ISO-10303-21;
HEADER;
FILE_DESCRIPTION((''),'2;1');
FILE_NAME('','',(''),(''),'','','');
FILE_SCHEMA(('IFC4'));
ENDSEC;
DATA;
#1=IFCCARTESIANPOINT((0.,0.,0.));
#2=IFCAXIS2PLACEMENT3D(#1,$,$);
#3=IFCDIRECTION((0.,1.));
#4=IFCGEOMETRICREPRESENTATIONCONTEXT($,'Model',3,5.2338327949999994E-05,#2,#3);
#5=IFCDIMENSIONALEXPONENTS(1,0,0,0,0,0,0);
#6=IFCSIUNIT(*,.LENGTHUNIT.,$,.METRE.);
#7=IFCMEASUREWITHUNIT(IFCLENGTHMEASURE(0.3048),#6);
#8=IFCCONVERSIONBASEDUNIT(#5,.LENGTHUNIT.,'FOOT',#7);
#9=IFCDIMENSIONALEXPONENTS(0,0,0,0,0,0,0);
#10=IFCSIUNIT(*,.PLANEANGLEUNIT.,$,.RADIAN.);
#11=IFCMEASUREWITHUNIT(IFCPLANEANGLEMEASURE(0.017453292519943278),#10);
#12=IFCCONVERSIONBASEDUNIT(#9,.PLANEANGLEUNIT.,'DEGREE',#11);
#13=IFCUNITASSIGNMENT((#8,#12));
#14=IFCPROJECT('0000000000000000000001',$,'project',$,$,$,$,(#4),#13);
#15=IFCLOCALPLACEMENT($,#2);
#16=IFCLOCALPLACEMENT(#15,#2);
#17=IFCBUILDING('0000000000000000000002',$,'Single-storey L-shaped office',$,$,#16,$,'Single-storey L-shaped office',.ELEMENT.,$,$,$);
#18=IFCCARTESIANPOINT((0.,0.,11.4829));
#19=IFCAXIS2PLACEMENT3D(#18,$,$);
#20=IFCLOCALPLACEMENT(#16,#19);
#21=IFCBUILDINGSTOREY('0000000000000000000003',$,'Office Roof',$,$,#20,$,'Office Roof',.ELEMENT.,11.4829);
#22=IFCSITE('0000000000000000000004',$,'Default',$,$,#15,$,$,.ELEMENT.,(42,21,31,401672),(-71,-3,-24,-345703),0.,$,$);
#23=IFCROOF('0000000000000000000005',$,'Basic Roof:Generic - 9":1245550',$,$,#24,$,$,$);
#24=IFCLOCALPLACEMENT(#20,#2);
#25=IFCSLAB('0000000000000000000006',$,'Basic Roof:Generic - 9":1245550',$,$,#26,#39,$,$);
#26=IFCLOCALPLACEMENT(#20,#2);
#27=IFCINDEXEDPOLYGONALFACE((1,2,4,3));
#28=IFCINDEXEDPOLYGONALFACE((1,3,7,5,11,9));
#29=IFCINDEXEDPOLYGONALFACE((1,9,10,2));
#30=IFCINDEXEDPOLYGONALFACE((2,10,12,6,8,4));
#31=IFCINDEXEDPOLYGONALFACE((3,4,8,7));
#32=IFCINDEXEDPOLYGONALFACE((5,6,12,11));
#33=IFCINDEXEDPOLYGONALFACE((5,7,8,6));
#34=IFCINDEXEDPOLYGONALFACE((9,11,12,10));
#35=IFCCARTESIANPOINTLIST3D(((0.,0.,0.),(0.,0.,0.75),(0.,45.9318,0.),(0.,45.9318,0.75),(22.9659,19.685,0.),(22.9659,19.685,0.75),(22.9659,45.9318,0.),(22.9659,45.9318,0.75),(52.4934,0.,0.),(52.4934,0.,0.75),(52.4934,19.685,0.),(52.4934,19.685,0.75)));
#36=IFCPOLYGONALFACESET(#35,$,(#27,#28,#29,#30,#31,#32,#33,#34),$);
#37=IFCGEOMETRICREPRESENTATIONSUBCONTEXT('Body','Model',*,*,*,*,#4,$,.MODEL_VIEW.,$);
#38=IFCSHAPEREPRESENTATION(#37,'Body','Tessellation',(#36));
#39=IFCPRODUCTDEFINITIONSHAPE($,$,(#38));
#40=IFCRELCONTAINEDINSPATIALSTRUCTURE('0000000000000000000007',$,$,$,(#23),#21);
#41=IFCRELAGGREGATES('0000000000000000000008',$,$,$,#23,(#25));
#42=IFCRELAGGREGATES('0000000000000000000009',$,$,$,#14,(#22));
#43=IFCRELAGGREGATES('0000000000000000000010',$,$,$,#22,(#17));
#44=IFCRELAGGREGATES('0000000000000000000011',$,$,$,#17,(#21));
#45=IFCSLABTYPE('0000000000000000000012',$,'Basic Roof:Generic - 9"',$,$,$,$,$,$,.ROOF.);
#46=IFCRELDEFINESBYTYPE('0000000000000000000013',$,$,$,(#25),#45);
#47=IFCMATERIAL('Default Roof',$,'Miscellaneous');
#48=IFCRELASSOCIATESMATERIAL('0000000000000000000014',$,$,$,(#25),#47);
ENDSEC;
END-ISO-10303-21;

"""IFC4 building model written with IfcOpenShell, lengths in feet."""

from ifc_helpers import new_model, entity, si_unit, converted_unit, direction, frame, origin, place, context, subcontext, project, spatial, indexed_curve, outline, extrude, material, type_object, element, aggregate, save


model = new_model("IFC4")

# Units and contexts
model_context = context("Model", 3, precision=5.2338327949999994e-05, world=origin(), true_north=direction((0.0, 1.0)))
body_context = subcontext(model_context, "Body", "Model", "MODEL_VIEW")
ifc_project = project(units=[converted_unit("LENGTHUNIT", "FOOT", entity("IfcLengthMeasure", 0.3048), si_unit("LENGTHUNIT", "METRE"), dimensions=[1, 0, 0, 0, 0, 0, 0]), converted_unit("PLANEANGLEUNIT", "DEGREE", entity("IfcPlaneAngleMeasure", 0.017453292519943278), si_unit("PLANEANGLEUNIT", "RADIAN"), dimensions=[0, 0, 0, 0, 0, 0, 0])], contexts=[model_context])

# Site, building, storey
site_placement = place(None, origin())
site = spatial("IfcSite", under=ifc_project, at=site_placement, Name="Default", CompositionType="ELEMENT", RefLatitude=(42, 21, 31, 401672), RefLongitude=(-71, -3, -24, -345703), RefElevation=0.0)
building_placement = place(site_placement, origin())
building = spatial("IfcBuilding", under=site, at=building_placement, Name="Single-storey L-shaped office", LongName="Single-storey L-shaped office", CompositionType="ELEMENT")
storey_placement = place(building_placement, frame((0.0, 0.0, 11.4829)))
storey = spatial("IfcBuildingStorey", under=building, at=storey_placement, Name="Office Roof", LongName="Office Roof", CompositionType="ELEMENT", Elevation=11.4829)

# Roof, slab
roof_placement = place(storey_placement, origin())
roof = element("IfcRoof", 1, at=roof_placement, inside=storey, Name="Basic Roof:Generic - 9\":1245550")
ifc_material = material(Name="Default Roof", Category="Miscellaneous")
slab_type = type_object("IfcSlabType", Name="Basic Roof:Generic - 9\"", PredefinedType="ROOF")
slab_placement = place(roof_placement, origin())
slab = element("IfcSlab", 2, at=slab_placement, type_object=slab_type, material=ifc_material, Name="Basic Roof:Generic - 9\":1245550", context=body_context, shape_type="SweptSolid", body=[
    extrude(outline(indexed_curve([(26.2467, -22.9659), (26.2467, -3.2808), (-3.2808, -3.2808), (-3.2808, 22.9659), (-26.2467, 22.9659), (-26.2467, -22.9659), (26.2467, -22.9659)], self_intersect=False)), frame((26.2467, 22.9659, 0.0)), (0.0, 0.0, 1.0), 0.75),
])
aggregate(roof, [slab])

save(model, "model.ifc")
